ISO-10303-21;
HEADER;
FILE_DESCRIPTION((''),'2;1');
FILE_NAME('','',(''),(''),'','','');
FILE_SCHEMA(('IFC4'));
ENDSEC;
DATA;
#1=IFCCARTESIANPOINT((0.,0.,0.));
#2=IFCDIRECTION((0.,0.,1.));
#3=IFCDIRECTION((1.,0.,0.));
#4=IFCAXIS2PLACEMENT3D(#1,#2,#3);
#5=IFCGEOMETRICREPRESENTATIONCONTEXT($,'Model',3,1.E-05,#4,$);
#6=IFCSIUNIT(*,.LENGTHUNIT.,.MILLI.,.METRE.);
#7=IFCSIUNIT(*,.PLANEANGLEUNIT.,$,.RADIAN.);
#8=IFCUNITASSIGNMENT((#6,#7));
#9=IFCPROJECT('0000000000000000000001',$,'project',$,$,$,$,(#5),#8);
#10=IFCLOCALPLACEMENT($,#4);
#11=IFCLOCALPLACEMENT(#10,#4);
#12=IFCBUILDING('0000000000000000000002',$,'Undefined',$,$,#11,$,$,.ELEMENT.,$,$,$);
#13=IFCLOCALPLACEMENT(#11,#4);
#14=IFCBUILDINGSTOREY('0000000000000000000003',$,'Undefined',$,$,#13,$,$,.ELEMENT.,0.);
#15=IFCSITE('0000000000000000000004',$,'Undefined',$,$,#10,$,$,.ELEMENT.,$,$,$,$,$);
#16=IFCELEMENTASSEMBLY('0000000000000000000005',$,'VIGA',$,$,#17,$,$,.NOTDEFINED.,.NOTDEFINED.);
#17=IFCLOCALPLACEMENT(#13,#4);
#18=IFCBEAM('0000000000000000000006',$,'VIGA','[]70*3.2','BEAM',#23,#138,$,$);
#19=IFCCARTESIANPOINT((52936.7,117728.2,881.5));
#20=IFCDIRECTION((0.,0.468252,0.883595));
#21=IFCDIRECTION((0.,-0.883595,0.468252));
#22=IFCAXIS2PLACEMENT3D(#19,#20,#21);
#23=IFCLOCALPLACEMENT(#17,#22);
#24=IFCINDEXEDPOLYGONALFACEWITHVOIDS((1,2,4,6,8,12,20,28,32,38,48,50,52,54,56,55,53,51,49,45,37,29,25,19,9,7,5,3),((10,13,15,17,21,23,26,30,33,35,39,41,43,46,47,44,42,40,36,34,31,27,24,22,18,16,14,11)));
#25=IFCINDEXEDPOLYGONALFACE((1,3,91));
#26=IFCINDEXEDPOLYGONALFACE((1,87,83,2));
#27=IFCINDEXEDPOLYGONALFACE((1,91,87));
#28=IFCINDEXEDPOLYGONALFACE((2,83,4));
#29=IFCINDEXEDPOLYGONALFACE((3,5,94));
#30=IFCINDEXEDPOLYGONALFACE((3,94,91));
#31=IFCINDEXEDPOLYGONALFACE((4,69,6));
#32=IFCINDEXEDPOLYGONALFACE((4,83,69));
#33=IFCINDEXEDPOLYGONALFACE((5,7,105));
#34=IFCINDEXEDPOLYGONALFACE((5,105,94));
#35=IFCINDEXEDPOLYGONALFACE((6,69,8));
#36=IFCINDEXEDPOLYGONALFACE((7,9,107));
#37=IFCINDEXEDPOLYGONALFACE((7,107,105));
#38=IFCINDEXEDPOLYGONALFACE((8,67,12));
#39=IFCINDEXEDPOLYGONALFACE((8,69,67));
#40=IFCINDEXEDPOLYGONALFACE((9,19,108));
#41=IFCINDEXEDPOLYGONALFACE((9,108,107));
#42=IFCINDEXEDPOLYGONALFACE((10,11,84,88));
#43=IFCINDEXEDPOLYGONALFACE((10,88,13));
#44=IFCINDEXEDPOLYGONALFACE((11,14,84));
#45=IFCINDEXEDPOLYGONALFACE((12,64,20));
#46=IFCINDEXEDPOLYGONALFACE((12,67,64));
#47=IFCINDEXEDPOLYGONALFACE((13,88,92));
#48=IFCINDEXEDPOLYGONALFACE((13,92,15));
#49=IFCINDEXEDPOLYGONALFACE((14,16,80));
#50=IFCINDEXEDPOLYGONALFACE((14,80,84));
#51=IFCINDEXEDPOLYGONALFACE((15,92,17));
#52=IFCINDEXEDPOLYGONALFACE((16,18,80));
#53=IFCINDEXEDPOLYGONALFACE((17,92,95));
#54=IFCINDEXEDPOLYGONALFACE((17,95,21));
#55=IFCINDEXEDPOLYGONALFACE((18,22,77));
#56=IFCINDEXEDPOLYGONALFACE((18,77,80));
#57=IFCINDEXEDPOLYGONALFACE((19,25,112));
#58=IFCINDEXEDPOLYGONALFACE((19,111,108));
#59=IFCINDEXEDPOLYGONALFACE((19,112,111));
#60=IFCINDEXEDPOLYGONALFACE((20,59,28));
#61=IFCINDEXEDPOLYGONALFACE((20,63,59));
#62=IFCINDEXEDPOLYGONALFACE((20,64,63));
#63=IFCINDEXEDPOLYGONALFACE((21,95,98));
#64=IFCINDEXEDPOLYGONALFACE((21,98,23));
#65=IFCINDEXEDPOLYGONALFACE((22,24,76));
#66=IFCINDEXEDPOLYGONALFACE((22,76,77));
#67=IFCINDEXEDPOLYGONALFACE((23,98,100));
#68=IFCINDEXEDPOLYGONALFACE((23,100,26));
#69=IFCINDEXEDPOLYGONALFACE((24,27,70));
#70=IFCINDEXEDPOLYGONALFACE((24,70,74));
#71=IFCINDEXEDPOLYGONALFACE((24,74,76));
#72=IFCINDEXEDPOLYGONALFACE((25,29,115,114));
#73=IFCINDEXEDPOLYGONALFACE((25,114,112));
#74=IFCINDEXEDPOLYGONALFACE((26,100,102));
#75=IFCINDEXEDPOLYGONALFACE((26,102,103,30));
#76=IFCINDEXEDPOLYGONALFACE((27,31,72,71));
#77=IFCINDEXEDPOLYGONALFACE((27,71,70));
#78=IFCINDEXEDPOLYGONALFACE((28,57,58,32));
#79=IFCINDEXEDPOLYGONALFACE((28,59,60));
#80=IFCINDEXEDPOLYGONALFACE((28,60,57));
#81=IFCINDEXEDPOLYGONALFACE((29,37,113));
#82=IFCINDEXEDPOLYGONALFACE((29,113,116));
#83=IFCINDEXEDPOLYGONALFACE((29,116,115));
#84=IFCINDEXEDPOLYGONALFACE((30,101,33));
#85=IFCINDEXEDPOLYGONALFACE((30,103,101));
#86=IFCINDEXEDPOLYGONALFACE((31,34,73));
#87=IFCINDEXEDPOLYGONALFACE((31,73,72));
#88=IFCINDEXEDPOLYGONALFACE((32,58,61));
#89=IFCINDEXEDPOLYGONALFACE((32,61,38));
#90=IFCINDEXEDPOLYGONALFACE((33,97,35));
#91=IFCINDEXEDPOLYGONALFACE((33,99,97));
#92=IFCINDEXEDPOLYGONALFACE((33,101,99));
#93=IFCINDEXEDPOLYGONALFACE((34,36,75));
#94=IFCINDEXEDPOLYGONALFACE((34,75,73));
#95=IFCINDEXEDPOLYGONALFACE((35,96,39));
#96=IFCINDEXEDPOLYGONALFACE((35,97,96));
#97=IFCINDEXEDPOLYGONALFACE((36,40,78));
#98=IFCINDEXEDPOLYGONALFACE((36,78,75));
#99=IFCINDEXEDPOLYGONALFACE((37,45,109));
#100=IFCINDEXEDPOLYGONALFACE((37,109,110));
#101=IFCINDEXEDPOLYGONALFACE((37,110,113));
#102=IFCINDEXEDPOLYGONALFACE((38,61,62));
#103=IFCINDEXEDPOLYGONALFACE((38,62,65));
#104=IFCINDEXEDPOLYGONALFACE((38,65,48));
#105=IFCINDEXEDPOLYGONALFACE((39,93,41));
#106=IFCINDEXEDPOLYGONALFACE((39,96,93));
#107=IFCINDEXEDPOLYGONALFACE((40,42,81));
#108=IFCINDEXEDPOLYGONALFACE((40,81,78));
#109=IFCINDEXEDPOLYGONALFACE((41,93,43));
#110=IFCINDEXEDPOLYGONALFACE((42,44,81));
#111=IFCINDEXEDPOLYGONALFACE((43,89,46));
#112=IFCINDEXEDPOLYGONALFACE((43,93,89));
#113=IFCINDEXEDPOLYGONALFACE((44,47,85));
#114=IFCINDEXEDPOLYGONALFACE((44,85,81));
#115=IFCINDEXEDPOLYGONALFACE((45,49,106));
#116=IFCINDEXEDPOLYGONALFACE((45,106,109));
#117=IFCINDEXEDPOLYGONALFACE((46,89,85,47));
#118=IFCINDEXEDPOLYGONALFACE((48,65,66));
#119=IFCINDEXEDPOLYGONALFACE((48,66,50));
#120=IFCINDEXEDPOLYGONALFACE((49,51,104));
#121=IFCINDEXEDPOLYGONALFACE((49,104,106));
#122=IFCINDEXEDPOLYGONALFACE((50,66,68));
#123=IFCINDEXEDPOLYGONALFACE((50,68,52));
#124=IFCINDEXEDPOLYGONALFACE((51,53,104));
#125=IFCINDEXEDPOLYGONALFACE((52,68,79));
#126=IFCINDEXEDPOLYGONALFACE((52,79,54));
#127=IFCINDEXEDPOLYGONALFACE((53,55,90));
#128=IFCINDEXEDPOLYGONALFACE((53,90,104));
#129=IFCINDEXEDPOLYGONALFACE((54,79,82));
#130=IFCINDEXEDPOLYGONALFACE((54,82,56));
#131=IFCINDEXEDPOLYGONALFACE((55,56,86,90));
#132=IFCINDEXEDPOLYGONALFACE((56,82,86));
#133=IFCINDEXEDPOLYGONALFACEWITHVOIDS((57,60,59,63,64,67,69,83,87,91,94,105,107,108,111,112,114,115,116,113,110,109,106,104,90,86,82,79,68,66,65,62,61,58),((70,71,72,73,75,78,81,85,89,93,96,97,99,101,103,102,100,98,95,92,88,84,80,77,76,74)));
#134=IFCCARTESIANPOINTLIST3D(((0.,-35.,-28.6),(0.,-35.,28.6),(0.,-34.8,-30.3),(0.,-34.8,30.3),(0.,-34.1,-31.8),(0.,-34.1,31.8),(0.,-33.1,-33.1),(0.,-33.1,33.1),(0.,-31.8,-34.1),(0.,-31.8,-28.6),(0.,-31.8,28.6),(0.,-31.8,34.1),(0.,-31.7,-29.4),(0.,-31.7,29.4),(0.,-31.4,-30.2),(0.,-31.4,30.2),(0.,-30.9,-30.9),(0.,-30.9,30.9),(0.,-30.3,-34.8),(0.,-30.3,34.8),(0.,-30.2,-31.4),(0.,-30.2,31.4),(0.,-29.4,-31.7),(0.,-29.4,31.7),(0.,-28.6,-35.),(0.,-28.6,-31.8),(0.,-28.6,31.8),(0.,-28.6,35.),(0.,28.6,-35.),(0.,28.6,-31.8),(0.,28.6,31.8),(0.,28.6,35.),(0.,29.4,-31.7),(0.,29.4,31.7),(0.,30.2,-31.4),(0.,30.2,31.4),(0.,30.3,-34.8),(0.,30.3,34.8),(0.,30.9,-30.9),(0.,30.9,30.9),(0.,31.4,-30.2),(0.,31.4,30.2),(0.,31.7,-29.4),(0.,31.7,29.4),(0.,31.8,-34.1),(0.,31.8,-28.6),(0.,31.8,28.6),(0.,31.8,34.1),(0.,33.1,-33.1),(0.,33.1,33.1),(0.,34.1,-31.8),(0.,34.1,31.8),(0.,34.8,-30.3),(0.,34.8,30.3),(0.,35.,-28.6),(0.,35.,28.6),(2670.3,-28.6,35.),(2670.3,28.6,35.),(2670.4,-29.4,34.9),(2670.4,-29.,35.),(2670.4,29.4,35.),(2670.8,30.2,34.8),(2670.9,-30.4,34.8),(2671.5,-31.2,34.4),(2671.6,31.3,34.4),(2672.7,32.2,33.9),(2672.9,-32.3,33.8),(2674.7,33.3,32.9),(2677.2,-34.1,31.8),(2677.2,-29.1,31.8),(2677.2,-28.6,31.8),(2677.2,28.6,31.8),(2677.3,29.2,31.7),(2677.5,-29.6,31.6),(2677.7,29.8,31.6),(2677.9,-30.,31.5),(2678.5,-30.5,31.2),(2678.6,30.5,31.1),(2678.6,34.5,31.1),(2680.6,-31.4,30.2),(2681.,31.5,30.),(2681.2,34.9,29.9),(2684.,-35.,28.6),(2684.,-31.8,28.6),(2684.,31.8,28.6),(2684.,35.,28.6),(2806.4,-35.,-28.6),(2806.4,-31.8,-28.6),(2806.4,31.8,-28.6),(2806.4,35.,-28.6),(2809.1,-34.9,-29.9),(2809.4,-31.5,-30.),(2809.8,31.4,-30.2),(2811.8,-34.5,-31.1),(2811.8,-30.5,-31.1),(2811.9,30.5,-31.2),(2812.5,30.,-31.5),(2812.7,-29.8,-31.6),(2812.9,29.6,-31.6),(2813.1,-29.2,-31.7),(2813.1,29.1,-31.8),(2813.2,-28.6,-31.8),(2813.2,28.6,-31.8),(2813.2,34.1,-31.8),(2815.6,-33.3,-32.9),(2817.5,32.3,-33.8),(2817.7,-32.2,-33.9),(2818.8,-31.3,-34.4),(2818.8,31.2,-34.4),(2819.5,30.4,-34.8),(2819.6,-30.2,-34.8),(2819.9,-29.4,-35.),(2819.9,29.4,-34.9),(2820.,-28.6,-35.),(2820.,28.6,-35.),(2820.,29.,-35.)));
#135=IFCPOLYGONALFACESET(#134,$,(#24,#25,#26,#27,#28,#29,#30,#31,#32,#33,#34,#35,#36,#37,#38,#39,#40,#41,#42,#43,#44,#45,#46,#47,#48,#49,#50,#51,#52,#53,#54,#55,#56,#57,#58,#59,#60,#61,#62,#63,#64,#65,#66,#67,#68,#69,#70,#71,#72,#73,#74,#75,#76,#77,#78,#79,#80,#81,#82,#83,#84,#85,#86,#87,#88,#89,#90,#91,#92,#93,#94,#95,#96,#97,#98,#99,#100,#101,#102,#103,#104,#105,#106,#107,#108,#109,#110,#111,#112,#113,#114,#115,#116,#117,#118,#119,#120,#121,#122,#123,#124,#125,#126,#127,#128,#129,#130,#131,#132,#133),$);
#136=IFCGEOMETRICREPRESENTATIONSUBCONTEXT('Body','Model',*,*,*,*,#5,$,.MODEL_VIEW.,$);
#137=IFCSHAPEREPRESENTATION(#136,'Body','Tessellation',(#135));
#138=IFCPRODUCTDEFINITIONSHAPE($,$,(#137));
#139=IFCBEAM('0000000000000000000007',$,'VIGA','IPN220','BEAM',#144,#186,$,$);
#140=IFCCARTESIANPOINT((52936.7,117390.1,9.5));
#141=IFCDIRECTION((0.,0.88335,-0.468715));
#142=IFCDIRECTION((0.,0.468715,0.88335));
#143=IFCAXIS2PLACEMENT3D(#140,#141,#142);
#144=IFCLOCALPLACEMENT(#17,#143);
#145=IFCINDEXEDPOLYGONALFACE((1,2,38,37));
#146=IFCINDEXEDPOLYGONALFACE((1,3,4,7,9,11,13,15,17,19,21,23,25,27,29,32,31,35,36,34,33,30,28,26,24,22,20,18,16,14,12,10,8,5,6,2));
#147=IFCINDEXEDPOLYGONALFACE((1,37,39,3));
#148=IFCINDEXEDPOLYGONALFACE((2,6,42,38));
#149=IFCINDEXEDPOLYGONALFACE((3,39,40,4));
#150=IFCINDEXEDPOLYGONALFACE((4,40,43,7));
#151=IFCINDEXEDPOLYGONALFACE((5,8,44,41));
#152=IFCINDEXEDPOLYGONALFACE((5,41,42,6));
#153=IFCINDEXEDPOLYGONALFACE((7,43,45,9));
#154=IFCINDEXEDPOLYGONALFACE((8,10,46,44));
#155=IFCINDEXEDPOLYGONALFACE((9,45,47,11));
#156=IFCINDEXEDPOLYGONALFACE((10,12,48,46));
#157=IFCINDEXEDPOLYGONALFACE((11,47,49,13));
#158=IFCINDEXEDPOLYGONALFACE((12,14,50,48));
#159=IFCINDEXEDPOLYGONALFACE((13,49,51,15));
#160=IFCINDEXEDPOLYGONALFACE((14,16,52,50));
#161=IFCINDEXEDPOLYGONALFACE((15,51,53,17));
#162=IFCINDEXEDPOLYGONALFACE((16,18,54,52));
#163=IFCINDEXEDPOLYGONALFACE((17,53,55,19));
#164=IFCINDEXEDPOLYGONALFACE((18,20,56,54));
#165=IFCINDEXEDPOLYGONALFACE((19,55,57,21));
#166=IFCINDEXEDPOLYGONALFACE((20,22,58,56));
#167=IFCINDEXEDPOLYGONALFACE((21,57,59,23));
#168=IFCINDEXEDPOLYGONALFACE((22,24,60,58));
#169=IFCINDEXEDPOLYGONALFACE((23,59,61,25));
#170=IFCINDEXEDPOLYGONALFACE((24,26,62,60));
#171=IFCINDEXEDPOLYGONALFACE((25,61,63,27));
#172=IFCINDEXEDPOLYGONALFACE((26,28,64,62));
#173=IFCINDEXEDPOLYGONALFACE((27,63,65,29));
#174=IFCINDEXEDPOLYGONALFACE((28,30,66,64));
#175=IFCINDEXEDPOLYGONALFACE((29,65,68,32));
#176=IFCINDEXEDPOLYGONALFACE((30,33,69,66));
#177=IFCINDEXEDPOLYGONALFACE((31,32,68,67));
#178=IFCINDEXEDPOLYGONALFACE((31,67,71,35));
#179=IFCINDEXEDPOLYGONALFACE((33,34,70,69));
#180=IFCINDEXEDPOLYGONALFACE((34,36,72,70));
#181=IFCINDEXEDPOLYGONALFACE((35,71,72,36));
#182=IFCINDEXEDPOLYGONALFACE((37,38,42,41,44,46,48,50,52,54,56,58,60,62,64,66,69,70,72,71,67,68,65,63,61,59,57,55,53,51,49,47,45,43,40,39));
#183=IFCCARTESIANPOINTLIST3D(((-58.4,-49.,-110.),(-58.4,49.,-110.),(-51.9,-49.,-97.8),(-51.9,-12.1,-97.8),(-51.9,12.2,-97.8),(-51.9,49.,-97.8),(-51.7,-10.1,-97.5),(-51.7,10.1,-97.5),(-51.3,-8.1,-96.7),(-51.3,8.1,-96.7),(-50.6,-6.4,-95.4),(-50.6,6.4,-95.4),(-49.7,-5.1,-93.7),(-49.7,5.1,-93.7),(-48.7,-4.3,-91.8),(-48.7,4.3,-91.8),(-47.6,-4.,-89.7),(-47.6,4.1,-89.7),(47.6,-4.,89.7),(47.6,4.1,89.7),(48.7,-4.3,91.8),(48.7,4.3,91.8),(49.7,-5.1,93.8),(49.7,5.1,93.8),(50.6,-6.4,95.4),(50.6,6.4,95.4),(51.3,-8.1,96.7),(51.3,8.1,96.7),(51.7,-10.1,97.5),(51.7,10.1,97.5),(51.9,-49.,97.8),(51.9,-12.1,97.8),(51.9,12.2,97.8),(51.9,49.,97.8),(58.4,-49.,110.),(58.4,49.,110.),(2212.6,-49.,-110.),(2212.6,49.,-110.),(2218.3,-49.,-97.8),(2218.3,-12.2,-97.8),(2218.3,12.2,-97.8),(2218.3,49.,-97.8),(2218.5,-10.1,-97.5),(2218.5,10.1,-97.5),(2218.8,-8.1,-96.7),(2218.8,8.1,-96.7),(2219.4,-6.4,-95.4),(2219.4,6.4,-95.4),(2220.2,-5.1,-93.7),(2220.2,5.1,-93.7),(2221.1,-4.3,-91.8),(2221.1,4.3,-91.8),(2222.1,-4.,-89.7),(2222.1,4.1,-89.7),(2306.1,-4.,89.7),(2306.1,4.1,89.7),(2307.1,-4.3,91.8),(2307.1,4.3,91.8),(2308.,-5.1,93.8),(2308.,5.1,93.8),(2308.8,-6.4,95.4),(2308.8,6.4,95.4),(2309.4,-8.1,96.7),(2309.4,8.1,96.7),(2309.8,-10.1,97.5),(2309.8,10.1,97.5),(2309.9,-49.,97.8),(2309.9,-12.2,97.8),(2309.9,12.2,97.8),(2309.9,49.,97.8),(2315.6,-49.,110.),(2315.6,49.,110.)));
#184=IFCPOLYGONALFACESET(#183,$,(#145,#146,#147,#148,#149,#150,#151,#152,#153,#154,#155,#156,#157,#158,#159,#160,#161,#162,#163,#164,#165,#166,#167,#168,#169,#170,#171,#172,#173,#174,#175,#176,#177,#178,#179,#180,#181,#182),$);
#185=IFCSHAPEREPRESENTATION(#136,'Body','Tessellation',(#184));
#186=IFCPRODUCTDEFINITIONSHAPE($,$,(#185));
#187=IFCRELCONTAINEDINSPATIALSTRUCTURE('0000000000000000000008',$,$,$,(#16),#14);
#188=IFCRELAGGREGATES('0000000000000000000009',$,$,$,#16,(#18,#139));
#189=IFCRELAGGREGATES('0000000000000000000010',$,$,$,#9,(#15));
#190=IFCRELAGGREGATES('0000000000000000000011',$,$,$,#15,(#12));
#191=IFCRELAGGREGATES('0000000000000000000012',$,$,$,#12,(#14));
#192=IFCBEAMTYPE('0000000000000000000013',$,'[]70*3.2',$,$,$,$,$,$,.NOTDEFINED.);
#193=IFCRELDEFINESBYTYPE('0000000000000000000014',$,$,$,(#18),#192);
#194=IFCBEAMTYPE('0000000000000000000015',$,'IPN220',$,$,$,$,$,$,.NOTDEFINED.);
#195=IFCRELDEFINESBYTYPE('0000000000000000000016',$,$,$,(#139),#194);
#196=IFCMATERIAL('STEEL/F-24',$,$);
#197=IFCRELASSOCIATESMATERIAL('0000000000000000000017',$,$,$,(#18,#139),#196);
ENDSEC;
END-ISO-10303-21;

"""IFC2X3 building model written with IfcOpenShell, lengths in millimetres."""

from ifc_helpers import new_model, si_unit, frame, origin_with_axes, origin_2d_with_axis, place, context, subcontext, project, spatial, hollow_rectangle, i_section, extrude, clip, halfspace, material, type_object, element, aggregate, save


model = new_model("IFC2X3")

# Units and contexts
model_context = context("Model", 3, precision=1e-05, world=origin_with_axes())
body_context = subcontext(model_context, "Body", "Model", "MODEL_VIEW")
ifc_project = project(units=[si_unit("LENGTHUNIT", "METRE", prefix="MILLI"), si_unit("PLANEANGLEUNIT", "RADIAN")], contexts=[model_context])

# Site, building, storey
site_placement = place(None, origin_with_axes())
site = spatial("IfcSite", under=ifc_project, at=site_placement, Name="Undefined", CompositionType="ELEMENT")
building_placement = place(site_placement, origin_with_axes())
building = spatial("IfcBuilding", under=site, at=building_placement, Name="Undefined", CompositionType="ELEMENT")
storey_placement = place(building_placement, origin_with_axes())
storey = spatial("IfcBuildingStorey", under=building, at=storey_placement, Name="Undefined", CompositionType="ELEMENT", Elevation=0.0)

# Element assembly, beams
assembly_1_placement = place(storey_placement, origin_with_axes())
assembly_1 = element("IfcElementAssembly", 1, at=assembly_1_placement, inside=storey, Name="VIGA", AssemblyPlace="NOTDEFINED", PredefinedType="NOTDEFINED")
ifc_material_1 = material(Name="STEEL/F-24")
beam_type_1 = type_object("IfcBeamType", Name="[]70*3.2", PredefinedType="NOTDEFINED")
beam_1_placement = place(assembly_1_placement, frame((52936.7, 117728.2, 881.5), z_axis=(0.0, 0.468252, 0.883595), x_axis=(0.0, -0.883595, 0.468252)))
beam_1 = element("IfcBeam", 2, at=beam_1_placement, type_object=beam_type_1, material=ifc_material_1, Name="VIGA", Description="[]70*3.2", ObjectType="BEAM", context=body_context, shape_type="Clipping", body=[
    clip(extrude(hollow_rectangle(XDim=70.0, YDim=70.0, WallThickness=3.2, InnerFilletRadius=3.2, OuterFilletRadius=6.4, at=origin_2d_with_axis()), frame((2850.0, 0.0, 0.0), z_axis=(-1.0, 0.0, 0.0), x_axis=(0.0, -1.0, 0.0)), (0.0, 0.0, 1.0), 2850.0), halfspace(frame((2745.2, 40.0, 0.0), z_axis=(-0.423531, 0.0, -0.905881), x_axis=(0.905881, 0.0, -0.423531)), True)),
])
beam_type_2 = type_object("IfcBeamType", Name="IPN220", PredefinedType="NOTDEFINED")
beam_2_placement = place(assembly_1_placement, frame((52936.7, 117390.1, 9.5), z_axis=(0.0, 0.88335, -0.468715), x_axis=(0.0, 0.468715, 0.88335)))
beam_2 = element("IfcBeam", 3, at=beam_2_placement, type_object=beam_type_2, material=ifc_material_1, Name="VIGA", Description="IPN220", ObjectType="BEAM", context=body_context, shape_type="Clipping", body=[
    clip(clip(extrude(i_section(OverallWidth=98.0, OverallDepth=220.0, WebThickness=8.1, FlangeThickness=12.2, FilletRadius=8.1, at=origin_2d_with_axis()), frame((2385.9, 0.0, 0.0), z_axis=(-1.0, 0.0, 0.0), x_axis=(0.0, -1.0, 0.0)), (0.0, 0.0, 1.0), 2507.7), halfspace(frame((2264.1, 40.0, 0.0), z_axis=(-0.905659, 0.0, 0.424006), x_axis=(0.424006, 0.0, 0.905659)), True)), halfspace(frame((0.0, 40.0, 0.0), z_axis=(-0.88335, 0.0, 0.468715), x_axis=(-0.468715, 0.0, -0.88335)), False)),
])

aggregate(assembly_1, [beam_1, beam_2])

save(model, "model.ifc")
